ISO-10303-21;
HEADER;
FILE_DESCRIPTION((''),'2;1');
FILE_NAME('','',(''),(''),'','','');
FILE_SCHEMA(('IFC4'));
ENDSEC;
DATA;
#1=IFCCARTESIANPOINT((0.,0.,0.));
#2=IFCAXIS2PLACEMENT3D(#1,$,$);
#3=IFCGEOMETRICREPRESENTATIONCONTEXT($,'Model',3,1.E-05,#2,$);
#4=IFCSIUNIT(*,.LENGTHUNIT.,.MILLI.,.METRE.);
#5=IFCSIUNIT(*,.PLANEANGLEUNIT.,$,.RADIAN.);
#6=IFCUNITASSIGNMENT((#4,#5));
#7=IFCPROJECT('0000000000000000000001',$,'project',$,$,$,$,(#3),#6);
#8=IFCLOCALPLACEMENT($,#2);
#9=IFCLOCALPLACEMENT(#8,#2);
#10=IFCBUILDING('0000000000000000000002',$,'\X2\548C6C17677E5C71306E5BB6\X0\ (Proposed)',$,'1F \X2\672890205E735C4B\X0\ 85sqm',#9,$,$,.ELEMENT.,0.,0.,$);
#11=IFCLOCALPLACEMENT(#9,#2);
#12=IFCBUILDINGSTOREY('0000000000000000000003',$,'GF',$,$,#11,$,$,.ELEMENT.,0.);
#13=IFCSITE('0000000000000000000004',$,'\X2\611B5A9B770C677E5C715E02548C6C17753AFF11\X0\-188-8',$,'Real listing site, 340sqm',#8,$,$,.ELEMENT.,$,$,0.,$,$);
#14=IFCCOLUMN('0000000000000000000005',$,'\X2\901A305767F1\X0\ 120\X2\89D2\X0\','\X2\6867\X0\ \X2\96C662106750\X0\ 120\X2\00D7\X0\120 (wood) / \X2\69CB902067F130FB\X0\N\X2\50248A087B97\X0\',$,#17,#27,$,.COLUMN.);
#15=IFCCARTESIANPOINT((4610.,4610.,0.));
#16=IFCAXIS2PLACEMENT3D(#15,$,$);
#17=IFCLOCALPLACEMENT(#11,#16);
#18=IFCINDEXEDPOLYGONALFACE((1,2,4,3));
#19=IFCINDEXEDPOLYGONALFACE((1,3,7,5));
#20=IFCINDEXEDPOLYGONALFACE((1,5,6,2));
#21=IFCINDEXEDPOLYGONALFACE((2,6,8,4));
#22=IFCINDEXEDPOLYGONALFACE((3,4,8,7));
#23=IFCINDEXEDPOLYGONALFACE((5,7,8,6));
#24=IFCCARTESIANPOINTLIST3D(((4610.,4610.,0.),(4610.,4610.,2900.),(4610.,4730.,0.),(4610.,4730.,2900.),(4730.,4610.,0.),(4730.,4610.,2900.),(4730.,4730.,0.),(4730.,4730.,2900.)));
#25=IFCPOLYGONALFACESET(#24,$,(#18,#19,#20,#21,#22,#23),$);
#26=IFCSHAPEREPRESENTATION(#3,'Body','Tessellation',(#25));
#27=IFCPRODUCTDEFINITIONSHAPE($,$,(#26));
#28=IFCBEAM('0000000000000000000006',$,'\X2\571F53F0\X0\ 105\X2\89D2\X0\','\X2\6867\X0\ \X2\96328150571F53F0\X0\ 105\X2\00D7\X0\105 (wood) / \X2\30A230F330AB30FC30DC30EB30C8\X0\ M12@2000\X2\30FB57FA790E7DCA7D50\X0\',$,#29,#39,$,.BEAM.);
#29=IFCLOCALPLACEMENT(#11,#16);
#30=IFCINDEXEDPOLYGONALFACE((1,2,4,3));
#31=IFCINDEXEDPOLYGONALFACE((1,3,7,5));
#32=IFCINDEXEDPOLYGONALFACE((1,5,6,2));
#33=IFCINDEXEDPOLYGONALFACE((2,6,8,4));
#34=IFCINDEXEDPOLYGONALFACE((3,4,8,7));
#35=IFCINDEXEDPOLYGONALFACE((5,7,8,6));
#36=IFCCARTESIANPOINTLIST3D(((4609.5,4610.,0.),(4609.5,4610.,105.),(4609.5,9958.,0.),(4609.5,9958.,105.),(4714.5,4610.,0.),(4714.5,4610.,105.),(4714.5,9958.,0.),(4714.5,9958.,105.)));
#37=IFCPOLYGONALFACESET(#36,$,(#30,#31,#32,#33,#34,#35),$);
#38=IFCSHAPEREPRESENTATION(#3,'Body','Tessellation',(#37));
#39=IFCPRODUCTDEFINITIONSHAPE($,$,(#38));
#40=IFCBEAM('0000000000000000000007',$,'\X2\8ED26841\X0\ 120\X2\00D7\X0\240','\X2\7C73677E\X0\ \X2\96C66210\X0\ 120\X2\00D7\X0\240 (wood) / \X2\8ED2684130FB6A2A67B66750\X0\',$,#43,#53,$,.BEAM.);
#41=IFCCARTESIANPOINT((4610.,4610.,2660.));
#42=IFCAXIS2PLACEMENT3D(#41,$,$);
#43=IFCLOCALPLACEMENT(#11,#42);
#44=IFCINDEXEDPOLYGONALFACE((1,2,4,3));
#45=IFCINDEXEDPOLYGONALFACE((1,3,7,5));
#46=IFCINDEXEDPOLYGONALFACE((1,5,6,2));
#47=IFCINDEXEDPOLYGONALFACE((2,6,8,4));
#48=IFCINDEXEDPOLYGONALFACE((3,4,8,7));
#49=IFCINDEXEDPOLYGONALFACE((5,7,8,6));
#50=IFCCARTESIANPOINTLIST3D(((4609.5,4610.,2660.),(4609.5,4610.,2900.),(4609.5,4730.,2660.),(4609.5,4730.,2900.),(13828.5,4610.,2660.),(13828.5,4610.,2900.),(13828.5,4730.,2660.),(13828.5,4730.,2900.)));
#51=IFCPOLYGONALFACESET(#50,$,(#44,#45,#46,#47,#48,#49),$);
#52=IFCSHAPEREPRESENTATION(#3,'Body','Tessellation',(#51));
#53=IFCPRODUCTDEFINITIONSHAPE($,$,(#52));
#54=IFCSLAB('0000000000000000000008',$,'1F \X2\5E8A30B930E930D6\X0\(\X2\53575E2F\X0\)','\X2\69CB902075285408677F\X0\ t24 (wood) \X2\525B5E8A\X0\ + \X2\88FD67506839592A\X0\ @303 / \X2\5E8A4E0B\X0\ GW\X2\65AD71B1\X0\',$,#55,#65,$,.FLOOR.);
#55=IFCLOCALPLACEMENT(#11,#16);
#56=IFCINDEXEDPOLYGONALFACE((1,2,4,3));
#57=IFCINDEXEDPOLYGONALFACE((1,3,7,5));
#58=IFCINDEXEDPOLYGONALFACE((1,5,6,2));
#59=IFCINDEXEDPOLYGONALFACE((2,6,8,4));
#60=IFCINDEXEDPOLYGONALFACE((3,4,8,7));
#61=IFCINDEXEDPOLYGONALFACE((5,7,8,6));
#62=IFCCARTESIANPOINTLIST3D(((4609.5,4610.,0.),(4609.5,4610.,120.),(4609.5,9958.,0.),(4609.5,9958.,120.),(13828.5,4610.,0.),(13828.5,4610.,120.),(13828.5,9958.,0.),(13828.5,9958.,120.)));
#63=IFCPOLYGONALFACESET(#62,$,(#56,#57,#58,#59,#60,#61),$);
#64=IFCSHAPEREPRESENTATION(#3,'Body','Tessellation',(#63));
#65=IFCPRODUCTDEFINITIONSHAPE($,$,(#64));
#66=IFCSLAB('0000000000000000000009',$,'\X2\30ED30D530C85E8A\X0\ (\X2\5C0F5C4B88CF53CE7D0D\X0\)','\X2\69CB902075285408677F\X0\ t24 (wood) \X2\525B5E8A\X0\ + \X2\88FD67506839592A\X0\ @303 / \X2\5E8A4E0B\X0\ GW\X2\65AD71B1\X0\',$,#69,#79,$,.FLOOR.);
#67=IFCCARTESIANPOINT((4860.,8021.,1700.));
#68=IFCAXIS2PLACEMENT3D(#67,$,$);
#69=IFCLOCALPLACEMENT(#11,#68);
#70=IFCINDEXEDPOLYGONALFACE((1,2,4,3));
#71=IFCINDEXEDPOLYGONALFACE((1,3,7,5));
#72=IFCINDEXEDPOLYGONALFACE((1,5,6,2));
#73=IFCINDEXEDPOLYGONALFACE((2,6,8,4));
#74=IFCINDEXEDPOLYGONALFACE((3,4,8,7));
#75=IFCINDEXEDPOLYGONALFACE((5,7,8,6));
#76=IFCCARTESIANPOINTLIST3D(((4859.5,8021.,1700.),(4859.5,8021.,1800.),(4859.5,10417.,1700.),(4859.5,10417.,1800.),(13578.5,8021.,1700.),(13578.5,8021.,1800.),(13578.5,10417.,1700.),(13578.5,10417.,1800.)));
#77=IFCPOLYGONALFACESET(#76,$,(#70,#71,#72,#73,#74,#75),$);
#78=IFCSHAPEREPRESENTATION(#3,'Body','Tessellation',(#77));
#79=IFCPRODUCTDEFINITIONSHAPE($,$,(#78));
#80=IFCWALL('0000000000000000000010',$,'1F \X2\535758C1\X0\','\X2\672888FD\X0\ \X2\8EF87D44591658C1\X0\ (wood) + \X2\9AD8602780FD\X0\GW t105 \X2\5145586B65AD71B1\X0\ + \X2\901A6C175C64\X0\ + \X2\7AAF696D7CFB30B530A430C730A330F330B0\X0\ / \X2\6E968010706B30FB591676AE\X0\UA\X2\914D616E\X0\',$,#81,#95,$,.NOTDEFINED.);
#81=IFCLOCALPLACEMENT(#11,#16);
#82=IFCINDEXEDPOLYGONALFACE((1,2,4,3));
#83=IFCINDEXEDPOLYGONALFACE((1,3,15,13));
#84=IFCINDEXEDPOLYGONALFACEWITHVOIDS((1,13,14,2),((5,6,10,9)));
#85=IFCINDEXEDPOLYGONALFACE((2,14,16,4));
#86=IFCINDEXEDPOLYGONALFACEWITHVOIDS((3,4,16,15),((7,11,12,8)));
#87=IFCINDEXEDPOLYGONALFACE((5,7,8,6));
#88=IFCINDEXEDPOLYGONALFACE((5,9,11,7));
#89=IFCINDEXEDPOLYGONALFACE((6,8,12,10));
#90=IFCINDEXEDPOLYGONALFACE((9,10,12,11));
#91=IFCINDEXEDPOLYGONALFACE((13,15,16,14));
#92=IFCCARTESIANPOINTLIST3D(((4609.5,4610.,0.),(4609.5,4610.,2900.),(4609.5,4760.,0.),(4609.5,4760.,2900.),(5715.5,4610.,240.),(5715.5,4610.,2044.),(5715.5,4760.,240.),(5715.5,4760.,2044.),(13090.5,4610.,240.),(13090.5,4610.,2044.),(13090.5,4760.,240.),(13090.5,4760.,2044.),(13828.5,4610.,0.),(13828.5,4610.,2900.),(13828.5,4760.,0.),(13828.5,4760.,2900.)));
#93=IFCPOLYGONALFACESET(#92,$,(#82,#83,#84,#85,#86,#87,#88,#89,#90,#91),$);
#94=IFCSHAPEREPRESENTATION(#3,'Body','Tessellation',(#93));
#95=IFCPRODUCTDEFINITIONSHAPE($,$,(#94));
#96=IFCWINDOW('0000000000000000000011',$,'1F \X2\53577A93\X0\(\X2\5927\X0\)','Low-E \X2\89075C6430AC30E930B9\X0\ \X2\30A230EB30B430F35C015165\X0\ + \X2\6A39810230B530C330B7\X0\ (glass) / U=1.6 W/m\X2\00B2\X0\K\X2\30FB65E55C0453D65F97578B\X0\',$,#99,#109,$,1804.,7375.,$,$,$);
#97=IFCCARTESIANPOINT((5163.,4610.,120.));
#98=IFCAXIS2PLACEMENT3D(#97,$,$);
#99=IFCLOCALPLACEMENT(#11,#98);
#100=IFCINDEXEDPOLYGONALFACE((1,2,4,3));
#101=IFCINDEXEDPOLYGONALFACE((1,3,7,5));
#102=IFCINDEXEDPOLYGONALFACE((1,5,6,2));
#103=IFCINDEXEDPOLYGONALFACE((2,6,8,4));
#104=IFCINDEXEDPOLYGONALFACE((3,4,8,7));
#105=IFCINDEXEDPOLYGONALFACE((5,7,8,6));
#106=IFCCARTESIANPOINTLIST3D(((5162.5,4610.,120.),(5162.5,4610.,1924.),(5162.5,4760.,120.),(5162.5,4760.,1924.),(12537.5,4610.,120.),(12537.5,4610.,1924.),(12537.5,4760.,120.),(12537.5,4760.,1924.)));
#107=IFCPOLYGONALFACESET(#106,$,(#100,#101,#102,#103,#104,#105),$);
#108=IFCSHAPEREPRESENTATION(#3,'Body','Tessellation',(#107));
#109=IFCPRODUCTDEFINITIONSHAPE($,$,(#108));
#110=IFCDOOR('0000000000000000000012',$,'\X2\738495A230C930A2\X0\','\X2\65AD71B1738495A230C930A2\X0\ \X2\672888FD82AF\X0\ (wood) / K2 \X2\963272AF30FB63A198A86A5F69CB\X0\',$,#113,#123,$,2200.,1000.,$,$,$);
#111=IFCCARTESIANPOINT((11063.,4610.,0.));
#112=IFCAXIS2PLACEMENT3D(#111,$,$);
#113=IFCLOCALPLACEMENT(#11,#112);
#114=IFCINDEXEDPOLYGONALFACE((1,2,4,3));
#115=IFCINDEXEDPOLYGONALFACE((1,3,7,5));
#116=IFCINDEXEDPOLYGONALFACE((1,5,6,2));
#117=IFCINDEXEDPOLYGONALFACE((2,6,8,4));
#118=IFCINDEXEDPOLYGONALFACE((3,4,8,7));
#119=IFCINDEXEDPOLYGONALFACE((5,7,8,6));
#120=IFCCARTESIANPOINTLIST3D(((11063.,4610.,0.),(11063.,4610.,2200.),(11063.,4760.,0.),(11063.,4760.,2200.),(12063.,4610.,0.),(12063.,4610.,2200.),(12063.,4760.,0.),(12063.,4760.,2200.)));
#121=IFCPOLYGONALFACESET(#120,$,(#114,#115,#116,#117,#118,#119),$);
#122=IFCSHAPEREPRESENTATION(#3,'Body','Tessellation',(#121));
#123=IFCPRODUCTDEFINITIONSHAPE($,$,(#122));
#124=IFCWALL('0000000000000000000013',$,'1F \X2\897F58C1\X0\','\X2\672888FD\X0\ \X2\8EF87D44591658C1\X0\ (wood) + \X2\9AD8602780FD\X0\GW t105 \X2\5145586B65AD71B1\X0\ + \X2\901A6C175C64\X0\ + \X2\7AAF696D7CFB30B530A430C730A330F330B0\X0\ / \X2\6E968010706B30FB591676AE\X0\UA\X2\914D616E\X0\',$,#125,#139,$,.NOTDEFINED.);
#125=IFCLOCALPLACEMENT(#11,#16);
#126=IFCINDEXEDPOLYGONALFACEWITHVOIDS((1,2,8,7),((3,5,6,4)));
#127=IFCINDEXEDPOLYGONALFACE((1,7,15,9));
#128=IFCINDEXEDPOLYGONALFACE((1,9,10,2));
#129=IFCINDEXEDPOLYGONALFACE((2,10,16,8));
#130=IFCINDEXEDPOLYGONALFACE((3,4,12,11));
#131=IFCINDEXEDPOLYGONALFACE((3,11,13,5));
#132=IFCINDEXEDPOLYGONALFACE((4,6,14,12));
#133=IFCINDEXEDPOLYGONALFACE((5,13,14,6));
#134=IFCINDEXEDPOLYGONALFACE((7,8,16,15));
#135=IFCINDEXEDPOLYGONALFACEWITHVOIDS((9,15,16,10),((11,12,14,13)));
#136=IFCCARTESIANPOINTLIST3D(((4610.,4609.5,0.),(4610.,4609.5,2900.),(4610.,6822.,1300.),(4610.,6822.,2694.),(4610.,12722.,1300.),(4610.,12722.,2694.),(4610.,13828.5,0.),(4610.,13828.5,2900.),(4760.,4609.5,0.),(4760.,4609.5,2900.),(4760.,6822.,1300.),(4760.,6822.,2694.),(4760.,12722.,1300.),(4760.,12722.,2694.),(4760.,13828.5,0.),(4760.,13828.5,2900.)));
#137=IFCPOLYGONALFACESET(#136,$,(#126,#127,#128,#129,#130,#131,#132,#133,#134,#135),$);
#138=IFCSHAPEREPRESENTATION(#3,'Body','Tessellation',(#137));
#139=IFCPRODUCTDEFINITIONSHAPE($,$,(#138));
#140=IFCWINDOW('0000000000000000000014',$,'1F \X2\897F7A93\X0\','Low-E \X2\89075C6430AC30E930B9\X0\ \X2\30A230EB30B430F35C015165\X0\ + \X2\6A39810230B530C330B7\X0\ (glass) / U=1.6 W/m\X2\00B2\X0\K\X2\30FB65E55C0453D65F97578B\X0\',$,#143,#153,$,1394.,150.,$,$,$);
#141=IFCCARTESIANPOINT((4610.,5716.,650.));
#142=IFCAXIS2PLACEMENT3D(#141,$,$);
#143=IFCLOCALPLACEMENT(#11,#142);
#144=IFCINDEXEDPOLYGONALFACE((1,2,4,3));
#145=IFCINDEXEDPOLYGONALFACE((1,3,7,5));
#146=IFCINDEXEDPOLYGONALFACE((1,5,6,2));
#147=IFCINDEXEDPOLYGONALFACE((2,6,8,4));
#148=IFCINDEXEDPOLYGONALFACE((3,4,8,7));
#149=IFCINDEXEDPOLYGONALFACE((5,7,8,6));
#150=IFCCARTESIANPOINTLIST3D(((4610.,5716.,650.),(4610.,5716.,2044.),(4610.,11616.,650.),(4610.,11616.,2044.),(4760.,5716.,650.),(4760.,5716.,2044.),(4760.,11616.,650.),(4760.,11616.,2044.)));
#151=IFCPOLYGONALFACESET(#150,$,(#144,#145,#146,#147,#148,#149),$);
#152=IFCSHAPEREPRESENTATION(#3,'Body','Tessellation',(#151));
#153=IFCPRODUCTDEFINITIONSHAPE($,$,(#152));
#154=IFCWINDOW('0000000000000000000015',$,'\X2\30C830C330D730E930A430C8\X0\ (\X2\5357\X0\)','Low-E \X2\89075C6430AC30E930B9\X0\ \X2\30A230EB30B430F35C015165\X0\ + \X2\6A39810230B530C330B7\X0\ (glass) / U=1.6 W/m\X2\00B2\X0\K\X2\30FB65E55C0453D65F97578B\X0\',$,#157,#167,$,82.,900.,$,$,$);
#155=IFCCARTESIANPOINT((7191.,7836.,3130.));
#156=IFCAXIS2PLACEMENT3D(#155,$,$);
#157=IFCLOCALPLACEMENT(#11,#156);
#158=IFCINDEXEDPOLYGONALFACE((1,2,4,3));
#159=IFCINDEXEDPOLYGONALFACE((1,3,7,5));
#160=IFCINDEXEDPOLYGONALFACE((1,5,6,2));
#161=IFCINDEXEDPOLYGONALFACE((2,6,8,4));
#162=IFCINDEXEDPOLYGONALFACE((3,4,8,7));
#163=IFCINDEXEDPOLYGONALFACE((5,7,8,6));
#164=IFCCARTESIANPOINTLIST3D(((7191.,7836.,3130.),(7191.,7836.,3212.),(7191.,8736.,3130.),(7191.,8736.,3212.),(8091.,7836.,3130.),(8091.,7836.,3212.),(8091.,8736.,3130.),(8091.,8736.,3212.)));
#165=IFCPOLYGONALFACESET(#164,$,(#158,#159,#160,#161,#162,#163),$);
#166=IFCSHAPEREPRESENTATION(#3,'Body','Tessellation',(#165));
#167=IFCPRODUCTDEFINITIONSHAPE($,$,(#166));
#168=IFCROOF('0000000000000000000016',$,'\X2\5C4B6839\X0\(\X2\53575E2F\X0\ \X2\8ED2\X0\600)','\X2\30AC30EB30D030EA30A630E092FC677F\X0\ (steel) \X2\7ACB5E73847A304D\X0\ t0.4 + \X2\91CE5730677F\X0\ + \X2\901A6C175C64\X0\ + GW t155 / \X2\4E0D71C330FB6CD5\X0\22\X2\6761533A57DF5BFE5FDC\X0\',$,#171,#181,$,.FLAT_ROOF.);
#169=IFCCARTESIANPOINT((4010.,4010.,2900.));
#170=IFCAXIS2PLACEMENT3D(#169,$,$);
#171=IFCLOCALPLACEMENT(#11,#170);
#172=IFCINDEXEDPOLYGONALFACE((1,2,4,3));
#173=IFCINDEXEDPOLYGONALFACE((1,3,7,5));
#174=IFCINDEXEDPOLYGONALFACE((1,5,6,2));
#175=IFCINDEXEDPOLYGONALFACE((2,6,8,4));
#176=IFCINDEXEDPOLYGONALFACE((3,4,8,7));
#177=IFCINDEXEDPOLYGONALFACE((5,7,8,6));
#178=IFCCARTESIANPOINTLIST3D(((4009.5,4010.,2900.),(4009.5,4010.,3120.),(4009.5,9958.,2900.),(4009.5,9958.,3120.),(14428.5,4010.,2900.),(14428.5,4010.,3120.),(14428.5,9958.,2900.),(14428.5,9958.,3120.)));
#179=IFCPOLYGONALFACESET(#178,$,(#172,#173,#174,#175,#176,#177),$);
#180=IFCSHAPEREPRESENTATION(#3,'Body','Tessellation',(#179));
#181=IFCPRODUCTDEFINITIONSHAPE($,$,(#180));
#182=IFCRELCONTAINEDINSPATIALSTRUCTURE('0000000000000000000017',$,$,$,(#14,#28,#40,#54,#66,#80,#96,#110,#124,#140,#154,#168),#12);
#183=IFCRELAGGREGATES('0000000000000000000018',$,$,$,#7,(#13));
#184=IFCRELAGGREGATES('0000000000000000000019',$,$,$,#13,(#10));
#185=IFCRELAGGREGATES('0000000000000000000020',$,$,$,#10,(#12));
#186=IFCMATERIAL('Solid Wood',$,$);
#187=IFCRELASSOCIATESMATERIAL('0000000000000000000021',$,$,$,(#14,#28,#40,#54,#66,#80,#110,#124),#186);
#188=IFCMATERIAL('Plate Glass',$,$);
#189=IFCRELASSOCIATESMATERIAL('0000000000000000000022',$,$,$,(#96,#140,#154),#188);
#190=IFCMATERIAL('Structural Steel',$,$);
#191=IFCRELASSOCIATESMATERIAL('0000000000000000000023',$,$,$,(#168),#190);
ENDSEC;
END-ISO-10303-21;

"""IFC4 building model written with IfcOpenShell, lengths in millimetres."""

from ifc_helpers import new_model, si_unit, frame, frame_2d, origin, place, context, project, spatial, rectangle, extrude, material, element, fill, save


model = new_model("IFC4")

# Units and contexts
model_context = context("Model", 3, precision=1e-05, world=origin())
ifc_project = project(units=[si_unit("LENGTHUNIT", "METRE", prefix="MILLI"), si_unit("PLANEANGLEUNIT", "RADIAN")], contexts=[model_context])

# Site, building, storey
site_placement = place(None, origin())
site = spatial("IfcSite", under=ifc_project, at=site_placement, Name="愛媛県松山市和気町１-188-8", ObjectType="Real listing site, 340sqm", CompositionType="ELEMENT", RefElevation=0.0)
building_placement = place(site_placement, origin())
building = spatial("IfcBuilding", under=site, at=building_placement, Name="和気松山の家 (Proposed)", ObjectType="1F 木造平屋 85sqm", CompositionType="ELEMENT", ElevationOfRefHeight=0.0, ElevationOfTerrain=0.0)
storey_placement = place(building_placement, origin())
storey = spatial("IfcBuildingStorey", under=building, at=storey_placement, Name="GF", CompositionType="ELEMENT", Elevation=0.0)

# Column
ifc_material_1 = material(Name="Solid Wood")
column_1_placement = place(storey_placement, frame((4610.0, 4610.0, 0.0)))
element("IfcColumn", 1, at=column_1_placement, inside=storey, material=ifc_material_1, Name="通し柱 120角", Description="桧 集成材 120×120 (wood) / 構造柱・N値計算", PredefinedType="COLUMN", context=model_context, shape_type="SweptSolid", body=[
    extrude(rectangle(XDim=120.0, YDim=120.0, at=frame_2d((60.0, 60.0))), frame((4610.0, 4610.0, 0.0)), (0.0, 0.0, 1.0), 2900.0),
])

# Beams
beam_1_placement = place(storey_placement, frame((4610.0, 4610.0, 0.0)))
element("IfcBeam", 2, at=beam_1_placement, inside=storey, material=ifc_material_1, Name="土台 105角", Description="桧 防腐土台 105×105 (wood) / アンカーボルト M12@2000・基礎緊結", PredefinedType="BEAM", context=model_context, shape_type="SweptSolid", body=[
    extrude(rectangle(XDim=105.0, YDim=5348.0, at=frame_2d((52.0, 2674.0))), frame((4610.0, 4610.0, 0.0)), (0.0, 0.0, 1.0), 105.0),
])
beam_2_placement = place(storey_placement, frame((4610.0, 4610.0, 2660.0)))
element("IfcBeam", 3, at=beam_2_placement, inside=storey, material=ifc_material_1, Name="軒桁 120×240", Description="米松 集成 120×240 (wood) / 軒桁・横架材", PredefinedType="BEAM", context=model_context, shape_type="SweptSolid", body=[
    extrude(rectangle(XDim=9219.0, YDim=120.0, at=frame_2d((4609.0, 60.0))), frame((4610.0, 4610.0, 2660.0)), (0.0, 0.0, 1.0), 240.0),
])

# Slabs
slab_1_placement = place(storey_placement, frame((4610.0, 4610.0, 0.0)))
element("IfcSlab", 4, at=slab_1_placement, inside=storey, material=ifc_material_1, Name="1F 床スラブ(南帯)", Description="構造用合板 t24 (wood) 剛床 + 製材根太 @303 / 床下 GW断熱", PredefinedType="FLOOR", context=model_context, shape_type="SweptSolid", body=[
    extrude(rectangle(XDim=9219.0, YDim=5348.0, at=frame_2d((4609.0, 2674.0))), frame((4610.0, 4610.0, 0.0)), (0.0, 0.0, 1.0), 120.0),
])
slab_2_placement = place(storey_placement, frame((4860.0, 8021.0, 1700.0)))
element("IfcSlab", 5, at=slab_2_placement, inside=storey, material=ifc_material_1, Name="ロフト床 (小屋裏収納)", Description="構造用合板 t24 (wood) 剛床 + 製材根太 @303 / 床下 GW断熱", PredefinedType="FLOOR", context=model_context, shape_type="SweptSolid", body=[
    extrude(rectangle(XDim=8719.0, YDim=2396.0, at=frame_2d((4359.0, 1198.0))), frame((4860.0, 8021.0, 1700.0)), (0.0, 0.0, 1.0), 100.0),
])

# Wall, openings, window, door
wall_1_placement = place(storey_placement, frame((4610.0, 4610.0, 0.0)))
wall_1 = element("IfcWall", 6, at=wall_1_placement, inside=storey, material=ifc_material_1, Name="1F 南壁", Description="木製 軸組外壁 (wood) + 高性能GW t105 充填断熱 + 通気層 + 窯業系サイディング / 準耐火・外皮UA配慮", PredefinedType="NOTDEFINED", context=model_context, shape_type="SweptSolid", body=[
    extrude(rectangle(XDim=9219.0, YDim=150.0, at=frame_2d((4609.0, 75.0))), frame((4610.0, 4610.0, 0.0)), (0.0, 0.0, 1.0), 2900.0),
])
opening_1_placement = place(storey_placement, frame((5163.0, 4610.0, 120.0)))
opening_1 = element("IfcOpeningElement", 7, at=opening_1_placement, cuts=wall_1, PredefinedType="NOTDEFINED", context=model_context, shape_type="SweptSolid", body=[
    extrude(rectangle(XDim=7375.0, YDim=150.0, at=frame_2d((3687.0, 75.0))), frame((5163.0, 4610.0, 120.0)), (0.0, 0.0, 1.0), 1804.0),
])
opening_2_placement = place(storey_placement, frame((11063.0, 4610.0, 0.0)))
opening_2 = element("IfcOpeningElement", 8, at=opening_2_placement, cuts=wall_1, PredefinedType="NOTDEFINED", context=model_context, shape_type="SweptSolid", body=[
    extrude(rectangle(XDim=1000.0, YDim=150.0, at=frame_2d((500.0, 75.0))), frame((11063.0, 4610.0, 0.0)), (0.0, 0.0, 1.0), 2200.0),
])
ifc_material_2 = material(Name="Plate Glass")
window_1_placement = place(storey_placement, frame((5163.0, 4610.0, 120.0)))
window_1 = element("IfcWindow", 9, at=window_1_placement, inside=storey, material=ifc_material_2, Name="1F 南窓(大)", Description="Low-E 複層ガラス アルゴン封入 + 樹脂サッシ (glass) / U=1.6 W/m²K・日射取得型", OverallHeight=1804.0, OverallWidth=7375.0, context=model_context, shape_type="SweptSolid", body=[
    extrude(rectangle(XDim=7375.0, YDim=150.0, at=frame_2d((3687.0, 75.0))), frame((5163.0, 4610.0, 120.0)), (0.0, 0.0, 1.0), 1804.0),
])
fill(opening_1, window_1)
door_1_placement = place(storey_placement, frame((11063.0, 4610.0, 0.0)))
door_1 = element("IfcDoor", 10, at=door_1_placement, inside=storey, material=ifc_material_1, Name="玄関ドア", Description="断熱玄関ドア 木製芯 (wood) / K2 防犯・採風機構", OverallHeight=2200.0, OverallWidth=1000.0, context=model_context, shape_type="SweptSolid", body=[
    extrude(rectangle(XDim=1000.0, YDim=150.0, at=frame_2d((500.0, 75.0))), frame((11063.0, 4610.0, 0.0)), (0.0, 0.0, 1.0), 2200.0),
])
fill(opening_2, door_1)

# Wall, opening, window
wall_2_placement = place(storey_placement, frame((4610.0, 4610.0, 0.0)))
wall_2 = element("IfcWall", 11, at=wall_2_placement, inside=storey, material=ifc_material_1, Name="1F 西壁", Description="木製 軸組外壁 (wood) + 高性能GW t105 充填断熱 + 通気層 + 窯業系サイディング / 準耐火・外皮UA配慮", PredefinedType="NOTDEFINED", context=model_context, shape_type="SweptSolid", body=[
    extrude(rectangle(XDim=150.0, YDim=9219.0, at=frame_2d((75.0, 4609.0))), frame((4610.0, 4610.0, 0.0)), (0.0, 0.0, 1.0), 2900.0),
])
opening_3_placement = place(storey_placement, frame((4610.0, 5716.0, 650.0)))
opening_3 = element("IfcOpeningElement", 12, at=opening_3_placement, cuts=wall_2, PredefinedType="NOTDEFINED", context=model_context, shape_type="SweptSolid", body=[
    extrude(rectangle(XDim=150.0, YDim=5900.0, at=frame_2d((75.0, 2950.0))), frame((4610.0, 5716.0, 650.0)), (0.0, 0.0, 1.0), 1394.0),
])
window_2_placement = place(storey_placement, frame((4610.0, 5716.0, 650.0)))
window_2 = element("IfcWindow", 13, at=window_2_placement, inside=storey, material=ifc_material_2, Name="1F 西窓", Description="Low-E 複層ガラス アルゴン封入 + 樹脂サッシ (glass) / U=1.6 W/m²K・日射取得型", OverallHeight=1394.0, OverallWidth=150.0, context=model_context, shape_type="SweptSolid", body=[
    extrude(rectangle(XDim=150.0, YDim=5900.0, at=frame_2d((75.0, 2950.0))), frame((4610.0, 5716.0, 650.0)), (0.0, 0.0, 1.0), 1394.0),
])
fill(opening_3, window_2)

# Window
window_3_placement = place(storey_placement, frame((7191.0, 7836.0, 3130.0)))
element("IfcWindow", 14, at=window_3_placement, inside=storey, material=ifc_material_2, Name="トップライト (南)", Description="Low-E 複層ガラス アルゴン封入 + 樹脂サッシ (glass) / U=1.6 W/m²K・日射取得型", OverallHeight=82.0, OverallWidth=900.0, context=model_context, shape_type="SweptSolid", body=[
    extrude(rectangle(XDim=900.0, YDim=900.0, at=frame_2d((450.0, 450.0))), frame((7191.0, 7836.0, 3130.0)), (0.0, 0.0, 1.0), 82.0),
])

# Roof
ifc_material_3 = material(Name="Structural Steel")
roof_placement = place(storey_placement, frame((4010.0, 4010.0, 2900.0)))
element("IfcRoof", 15, at=roof_placement, inside=storey, material=ifc_material_3, Name="屋根(南帯 軒600)", Description="ガルバリウム鋼板 (steel) 立平葺き t0.4 + 野地板 + 通気層 + GW t155 / 不燃・法22条区域対応", PredefinedType="FLAT_ROOF", context=model_context, shape_type="SweptSolid", body=[
    extrude(rectangle(XDim=10419.0, YDim=5948.0, at=frame_2d((5209.0, 2974.0))), frame((4010.0, 4010.0, 2900.0)), (0.0, 0.0, 1.0), 220.0),
])

save(model, "model.ifc")
